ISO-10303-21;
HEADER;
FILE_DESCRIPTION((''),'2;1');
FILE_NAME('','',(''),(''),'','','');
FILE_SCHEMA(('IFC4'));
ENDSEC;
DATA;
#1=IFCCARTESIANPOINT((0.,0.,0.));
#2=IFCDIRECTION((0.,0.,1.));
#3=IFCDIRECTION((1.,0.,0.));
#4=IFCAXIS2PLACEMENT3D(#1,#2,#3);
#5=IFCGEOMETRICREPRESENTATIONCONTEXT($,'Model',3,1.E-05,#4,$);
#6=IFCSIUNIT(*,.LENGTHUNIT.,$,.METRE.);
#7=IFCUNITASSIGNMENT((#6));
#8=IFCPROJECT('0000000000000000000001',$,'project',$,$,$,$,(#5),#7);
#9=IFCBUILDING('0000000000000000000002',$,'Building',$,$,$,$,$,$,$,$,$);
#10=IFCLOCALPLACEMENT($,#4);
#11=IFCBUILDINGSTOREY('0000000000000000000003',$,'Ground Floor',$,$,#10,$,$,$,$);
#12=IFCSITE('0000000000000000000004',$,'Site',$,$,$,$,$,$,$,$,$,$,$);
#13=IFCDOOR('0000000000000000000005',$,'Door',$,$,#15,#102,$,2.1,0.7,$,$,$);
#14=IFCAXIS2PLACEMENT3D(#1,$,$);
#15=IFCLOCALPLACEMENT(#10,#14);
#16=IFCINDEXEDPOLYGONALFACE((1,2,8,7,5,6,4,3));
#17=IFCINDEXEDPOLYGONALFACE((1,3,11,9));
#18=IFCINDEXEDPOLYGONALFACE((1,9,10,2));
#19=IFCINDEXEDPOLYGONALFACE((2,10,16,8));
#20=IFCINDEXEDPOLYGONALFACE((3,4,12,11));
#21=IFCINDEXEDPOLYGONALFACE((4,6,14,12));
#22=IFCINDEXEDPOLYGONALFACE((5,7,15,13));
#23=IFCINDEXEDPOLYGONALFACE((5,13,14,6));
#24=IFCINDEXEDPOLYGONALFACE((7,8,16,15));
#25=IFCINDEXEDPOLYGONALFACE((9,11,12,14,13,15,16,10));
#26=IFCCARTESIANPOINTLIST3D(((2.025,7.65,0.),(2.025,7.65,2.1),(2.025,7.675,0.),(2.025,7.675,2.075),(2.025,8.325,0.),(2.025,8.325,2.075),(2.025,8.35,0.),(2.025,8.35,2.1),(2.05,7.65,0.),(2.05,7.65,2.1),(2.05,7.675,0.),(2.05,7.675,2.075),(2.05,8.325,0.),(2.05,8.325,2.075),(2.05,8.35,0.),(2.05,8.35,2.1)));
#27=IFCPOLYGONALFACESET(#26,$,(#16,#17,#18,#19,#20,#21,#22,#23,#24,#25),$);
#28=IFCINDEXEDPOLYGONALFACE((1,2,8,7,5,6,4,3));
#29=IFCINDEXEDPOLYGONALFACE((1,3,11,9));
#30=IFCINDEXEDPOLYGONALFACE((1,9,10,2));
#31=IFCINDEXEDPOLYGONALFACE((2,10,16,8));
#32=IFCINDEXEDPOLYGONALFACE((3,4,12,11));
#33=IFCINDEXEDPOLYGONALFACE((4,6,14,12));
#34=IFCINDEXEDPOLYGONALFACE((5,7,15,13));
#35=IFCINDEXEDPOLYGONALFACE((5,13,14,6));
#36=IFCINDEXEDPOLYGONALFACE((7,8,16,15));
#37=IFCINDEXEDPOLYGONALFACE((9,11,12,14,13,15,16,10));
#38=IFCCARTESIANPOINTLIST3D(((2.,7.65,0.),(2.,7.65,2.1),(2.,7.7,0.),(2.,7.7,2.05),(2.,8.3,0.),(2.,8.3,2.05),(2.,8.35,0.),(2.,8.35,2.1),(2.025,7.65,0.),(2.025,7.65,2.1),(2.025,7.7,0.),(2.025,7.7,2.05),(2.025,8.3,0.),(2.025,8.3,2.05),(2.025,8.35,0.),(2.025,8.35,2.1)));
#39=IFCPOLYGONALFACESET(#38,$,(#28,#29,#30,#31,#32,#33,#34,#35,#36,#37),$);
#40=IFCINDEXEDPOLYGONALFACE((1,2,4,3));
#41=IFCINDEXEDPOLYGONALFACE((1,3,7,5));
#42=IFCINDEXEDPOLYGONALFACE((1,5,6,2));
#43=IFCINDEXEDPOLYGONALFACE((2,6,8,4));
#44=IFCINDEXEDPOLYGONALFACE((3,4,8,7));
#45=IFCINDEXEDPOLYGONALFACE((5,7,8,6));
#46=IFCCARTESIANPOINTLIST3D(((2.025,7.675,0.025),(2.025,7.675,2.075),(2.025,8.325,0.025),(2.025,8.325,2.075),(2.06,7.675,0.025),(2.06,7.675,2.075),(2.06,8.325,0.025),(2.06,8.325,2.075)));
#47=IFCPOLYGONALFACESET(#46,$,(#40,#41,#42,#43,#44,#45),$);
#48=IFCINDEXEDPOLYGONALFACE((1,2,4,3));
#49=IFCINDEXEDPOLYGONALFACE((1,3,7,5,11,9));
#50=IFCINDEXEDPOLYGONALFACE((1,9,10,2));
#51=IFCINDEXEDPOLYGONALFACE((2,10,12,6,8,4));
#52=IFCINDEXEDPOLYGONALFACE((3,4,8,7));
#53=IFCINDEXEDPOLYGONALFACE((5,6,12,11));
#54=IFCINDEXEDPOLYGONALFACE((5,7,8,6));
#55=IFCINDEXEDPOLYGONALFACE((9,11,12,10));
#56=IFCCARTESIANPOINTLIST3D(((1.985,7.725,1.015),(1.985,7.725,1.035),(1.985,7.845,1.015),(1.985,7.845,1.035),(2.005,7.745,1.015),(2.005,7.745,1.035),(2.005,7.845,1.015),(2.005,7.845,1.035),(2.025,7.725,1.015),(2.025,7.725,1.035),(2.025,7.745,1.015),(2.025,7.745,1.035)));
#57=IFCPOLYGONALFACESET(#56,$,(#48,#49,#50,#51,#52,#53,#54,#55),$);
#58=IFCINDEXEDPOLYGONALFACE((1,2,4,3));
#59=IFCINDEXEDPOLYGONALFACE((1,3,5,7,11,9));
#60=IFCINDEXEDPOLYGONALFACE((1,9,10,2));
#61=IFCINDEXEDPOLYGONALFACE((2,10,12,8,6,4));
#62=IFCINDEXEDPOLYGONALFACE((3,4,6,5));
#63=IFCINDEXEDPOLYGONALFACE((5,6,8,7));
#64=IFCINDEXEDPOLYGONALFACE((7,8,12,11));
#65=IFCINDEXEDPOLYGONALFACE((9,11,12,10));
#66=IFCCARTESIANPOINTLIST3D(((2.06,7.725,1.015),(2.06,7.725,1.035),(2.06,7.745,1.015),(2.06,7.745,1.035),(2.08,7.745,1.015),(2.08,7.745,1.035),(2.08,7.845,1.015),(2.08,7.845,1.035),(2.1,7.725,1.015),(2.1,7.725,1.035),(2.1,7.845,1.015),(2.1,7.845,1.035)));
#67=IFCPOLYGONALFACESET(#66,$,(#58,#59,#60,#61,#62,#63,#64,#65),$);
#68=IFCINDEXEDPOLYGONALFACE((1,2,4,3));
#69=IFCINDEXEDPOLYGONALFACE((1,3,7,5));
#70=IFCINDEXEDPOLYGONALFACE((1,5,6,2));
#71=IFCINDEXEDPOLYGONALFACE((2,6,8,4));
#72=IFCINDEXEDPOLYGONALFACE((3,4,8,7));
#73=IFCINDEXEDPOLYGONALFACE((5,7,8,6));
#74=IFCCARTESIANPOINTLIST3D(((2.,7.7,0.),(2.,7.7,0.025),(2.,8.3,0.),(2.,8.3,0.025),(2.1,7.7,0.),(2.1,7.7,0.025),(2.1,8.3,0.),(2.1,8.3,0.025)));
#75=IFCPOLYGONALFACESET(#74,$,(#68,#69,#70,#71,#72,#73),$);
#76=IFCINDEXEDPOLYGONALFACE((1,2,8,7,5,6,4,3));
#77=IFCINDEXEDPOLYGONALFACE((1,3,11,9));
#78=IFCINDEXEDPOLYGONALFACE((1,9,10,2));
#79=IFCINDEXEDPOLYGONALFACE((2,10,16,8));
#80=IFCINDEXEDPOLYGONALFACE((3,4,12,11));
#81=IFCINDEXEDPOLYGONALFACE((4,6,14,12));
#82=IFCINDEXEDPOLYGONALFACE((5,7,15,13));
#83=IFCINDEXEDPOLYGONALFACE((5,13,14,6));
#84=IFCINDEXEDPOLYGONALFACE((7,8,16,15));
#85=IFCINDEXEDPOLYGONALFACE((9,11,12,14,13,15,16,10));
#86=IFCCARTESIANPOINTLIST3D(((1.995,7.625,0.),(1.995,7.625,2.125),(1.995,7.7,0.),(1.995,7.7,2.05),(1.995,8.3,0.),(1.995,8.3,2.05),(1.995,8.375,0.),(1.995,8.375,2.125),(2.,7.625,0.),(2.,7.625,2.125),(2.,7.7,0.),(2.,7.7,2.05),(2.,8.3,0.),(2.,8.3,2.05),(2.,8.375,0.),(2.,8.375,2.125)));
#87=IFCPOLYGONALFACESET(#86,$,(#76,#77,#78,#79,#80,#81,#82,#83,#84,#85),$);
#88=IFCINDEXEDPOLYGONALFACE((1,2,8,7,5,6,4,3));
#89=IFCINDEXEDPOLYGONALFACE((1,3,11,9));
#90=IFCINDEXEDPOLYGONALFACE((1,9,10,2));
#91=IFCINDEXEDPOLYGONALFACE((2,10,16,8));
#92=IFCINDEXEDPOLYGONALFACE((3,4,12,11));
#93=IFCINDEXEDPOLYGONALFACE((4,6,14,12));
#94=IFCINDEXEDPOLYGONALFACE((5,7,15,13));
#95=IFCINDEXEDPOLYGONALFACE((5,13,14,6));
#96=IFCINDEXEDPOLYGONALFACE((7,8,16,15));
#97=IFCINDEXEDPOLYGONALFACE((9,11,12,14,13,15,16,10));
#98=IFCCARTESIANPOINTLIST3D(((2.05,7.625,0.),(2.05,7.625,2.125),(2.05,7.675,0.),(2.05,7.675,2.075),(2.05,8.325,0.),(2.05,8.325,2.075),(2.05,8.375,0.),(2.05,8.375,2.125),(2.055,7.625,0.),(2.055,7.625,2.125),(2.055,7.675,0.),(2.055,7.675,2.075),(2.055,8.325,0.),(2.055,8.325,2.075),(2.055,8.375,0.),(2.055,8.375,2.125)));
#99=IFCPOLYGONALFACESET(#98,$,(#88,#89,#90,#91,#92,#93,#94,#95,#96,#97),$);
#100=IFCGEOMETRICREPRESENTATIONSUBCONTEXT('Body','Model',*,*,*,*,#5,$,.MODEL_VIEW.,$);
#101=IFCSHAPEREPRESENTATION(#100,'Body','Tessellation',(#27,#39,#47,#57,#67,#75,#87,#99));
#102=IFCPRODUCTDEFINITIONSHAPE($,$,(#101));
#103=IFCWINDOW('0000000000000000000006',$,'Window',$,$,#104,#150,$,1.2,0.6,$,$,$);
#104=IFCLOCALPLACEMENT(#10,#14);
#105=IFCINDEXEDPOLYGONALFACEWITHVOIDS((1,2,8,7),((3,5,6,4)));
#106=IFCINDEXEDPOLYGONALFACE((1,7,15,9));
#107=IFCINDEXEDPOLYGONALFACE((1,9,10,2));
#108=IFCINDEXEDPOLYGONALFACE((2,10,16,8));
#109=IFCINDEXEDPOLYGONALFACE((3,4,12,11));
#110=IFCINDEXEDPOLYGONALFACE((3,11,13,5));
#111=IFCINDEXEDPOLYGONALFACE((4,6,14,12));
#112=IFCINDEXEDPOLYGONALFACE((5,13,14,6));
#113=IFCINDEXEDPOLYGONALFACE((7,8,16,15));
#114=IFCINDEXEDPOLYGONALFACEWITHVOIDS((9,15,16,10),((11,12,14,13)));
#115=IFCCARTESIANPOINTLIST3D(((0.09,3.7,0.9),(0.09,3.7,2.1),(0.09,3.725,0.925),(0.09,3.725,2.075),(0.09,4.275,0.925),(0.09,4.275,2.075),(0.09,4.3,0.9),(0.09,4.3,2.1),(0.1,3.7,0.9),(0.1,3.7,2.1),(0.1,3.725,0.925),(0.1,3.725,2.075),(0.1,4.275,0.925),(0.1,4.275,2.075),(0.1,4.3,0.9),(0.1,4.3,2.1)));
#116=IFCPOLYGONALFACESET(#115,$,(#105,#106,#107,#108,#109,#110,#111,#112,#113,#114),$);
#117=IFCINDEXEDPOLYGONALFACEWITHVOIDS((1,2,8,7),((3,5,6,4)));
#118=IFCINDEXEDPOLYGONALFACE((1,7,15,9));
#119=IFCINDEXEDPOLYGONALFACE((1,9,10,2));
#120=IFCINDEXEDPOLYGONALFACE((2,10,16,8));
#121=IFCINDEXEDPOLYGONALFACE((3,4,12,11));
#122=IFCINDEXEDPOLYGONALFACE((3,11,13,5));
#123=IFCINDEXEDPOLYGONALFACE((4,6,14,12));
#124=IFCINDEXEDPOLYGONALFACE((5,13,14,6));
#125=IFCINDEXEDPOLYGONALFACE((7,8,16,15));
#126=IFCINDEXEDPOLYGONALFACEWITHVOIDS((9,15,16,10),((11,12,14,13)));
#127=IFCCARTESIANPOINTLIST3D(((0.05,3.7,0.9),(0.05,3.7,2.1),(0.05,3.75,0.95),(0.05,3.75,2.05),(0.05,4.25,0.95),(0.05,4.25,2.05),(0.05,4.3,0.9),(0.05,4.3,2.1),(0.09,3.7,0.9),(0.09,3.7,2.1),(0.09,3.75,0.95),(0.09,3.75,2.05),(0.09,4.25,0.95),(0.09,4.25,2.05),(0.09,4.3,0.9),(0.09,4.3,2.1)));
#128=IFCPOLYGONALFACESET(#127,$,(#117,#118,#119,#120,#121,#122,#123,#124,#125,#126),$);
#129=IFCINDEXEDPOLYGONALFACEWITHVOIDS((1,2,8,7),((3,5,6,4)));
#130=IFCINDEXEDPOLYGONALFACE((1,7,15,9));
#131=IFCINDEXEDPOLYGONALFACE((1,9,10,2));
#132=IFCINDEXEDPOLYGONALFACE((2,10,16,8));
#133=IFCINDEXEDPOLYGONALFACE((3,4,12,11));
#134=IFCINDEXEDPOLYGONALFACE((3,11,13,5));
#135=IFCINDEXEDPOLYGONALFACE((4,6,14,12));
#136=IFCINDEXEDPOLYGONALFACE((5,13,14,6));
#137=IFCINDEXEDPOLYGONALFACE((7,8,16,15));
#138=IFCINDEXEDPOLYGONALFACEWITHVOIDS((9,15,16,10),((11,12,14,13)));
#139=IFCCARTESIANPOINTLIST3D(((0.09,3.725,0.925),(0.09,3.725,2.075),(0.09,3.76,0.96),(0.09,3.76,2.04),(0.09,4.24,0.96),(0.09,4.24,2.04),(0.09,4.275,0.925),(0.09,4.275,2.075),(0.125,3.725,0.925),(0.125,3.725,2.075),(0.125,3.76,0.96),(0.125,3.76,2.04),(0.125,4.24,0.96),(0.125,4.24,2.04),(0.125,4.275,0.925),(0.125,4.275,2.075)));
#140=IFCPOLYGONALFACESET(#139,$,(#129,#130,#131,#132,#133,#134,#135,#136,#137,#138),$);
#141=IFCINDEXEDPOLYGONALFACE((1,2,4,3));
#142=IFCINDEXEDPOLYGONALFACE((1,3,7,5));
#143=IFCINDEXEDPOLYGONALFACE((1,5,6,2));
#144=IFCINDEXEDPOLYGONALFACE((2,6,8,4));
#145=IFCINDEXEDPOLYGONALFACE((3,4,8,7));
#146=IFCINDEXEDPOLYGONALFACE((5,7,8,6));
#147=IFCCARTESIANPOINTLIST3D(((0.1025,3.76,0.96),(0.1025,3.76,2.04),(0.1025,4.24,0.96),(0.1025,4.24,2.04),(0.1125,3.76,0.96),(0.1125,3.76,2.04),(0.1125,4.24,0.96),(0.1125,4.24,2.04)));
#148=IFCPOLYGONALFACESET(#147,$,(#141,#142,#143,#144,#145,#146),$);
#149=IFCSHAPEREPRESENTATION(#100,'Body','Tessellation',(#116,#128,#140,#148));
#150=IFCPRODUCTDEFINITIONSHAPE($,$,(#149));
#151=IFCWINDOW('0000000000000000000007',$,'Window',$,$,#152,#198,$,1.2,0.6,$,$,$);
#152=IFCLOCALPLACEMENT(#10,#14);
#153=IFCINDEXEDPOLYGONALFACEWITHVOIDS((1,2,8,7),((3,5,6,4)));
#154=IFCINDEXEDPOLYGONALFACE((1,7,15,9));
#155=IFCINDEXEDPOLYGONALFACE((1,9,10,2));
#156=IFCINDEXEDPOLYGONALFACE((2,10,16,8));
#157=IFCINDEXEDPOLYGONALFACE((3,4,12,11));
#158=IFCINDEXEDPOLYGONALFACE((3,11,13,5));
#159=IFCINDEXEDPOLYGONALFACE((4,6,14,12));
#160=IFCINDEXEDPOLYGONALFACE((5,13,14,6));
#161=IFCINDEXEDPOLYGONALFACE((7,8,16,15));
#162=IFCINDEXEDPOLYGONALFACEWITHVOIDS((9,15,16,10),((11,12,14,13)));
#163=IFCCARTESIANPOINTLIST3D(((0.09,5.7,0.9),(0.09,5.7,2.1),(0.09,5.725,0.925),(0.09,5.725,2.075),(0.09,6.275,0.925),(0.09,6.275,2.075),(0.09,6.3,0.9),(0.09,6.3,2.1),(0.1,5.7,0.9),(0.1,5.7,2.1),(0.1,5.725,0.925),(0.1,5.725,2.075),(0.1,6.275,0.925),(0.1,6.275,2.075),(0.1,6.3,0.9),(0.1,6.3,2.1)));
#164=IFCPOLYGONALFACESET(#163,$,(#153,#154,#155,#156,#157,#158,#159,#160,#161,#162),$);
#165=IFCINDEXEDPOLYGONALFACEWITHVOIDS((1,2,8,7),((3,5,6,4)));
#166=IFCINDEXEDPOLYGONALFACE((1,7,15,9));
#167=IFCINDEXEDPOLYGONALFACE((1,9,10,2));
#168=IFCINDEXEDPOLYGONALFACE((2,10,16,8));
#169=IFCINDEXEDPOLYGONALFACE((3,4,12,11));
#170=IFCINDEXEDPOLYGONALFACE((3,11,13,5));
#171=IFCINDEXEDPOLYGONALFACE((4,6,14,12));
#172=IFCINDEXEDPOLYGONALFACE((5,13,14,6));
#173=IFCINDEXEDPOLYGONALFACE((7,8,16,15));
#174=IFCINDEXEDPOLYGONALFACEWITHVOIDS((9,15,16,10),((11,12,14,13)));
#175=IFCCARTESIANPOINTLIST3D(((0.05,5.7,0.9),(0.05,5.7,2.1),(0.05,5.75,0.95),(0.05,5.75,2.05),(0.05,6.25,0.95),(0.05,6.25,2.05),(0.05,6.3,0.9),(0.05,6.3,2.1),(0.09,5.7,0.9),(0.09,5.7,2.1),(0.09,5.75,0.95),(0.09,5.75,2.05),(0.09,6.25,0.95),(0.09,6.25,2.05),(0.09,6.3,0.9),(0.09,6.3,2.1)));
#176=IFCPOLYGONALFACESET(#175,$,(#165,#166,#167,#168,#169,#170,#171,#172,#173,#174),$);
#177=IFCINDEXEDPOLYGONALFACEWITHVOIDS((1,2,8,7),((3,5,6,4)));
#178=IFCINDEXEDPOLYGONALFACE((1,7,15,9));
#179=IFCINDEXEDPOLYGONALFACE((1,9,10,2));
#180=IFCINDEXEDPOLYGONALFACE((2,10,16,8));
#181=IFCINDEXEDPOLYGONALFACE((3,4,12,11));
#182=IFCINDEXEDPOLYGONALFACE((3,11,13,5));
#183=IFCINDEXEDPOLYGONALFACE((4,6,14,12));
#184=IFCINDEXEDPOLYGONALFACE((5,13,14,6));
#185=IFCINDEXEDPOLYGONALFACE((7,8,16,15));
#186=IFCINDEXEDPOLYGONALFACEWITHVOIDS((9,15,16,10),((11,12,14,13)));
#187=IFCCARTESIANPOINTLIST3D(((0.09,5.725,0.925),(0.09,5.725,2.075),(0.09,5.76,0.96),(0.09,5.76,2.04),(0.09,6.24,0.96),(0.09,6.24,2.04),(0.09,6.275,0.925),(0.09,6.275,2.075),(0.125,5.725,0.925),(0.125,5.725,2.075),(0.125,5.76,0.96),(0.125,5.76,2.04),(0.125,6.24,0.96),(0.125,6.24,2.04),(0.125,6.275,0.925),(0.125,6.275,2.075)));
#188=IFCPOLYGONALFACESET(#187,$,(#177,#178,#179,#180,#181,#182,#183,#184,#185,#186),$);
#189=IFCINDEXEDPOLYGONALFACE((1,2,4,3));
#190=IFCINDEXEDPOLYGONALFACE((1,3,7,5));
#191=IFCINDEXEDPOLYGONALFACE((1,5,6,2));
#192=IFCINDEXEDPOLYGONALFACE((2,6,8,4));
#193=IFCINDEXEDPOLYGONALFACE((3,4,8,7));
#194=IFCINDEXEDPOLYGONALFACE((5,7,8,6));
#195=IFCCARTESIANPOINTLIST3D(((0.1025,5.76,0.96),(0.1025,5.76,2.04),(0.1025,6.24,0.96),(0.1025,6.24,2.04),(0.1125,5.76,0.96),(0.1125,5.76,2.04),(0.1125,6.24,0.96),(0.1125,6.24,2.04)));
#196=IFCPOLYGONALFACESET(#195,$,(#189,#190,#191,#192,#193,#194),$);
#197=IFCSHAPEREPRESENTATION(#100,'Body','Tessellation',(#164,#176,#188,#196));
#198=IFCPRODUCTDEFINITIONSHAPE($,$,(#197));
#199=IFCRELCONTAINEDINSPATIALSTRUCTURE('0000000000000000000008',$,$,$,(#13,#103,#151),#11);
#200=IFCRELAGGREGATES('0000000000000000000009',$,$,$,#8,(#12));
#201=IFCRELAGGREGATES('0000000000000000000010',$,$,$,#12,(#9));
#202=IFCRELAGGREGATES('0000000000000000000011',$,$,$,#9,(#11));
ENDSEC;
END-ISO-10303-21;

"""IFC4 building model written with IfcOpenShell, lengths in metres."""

from ifc_helpers import new_model, si_unit, frame, origin_with_axes, place, context, subcontext, project, spatial, line, indexed_curve, outline, extrude, element, save


model = new_model("IFC4")

# Units and contexts
model_context = context("Model", 3, precision=1e-05, world=origin_with_axes())
body_context = subcontext(model_context, "Body", "Model", "MODEL_VIEW")
ifc_project = project(units=[si_unit("LENGTHUNIT", "METRE")], contexts=[model_context])

# Site, building, storey
site = spatial("IfcSite", under=ifc_project, Name="Site")
building = spatial("IfcBuilding", under=site, Name="Building")
storey_placement = place(None, origin_with_axes())
storey = spatial("IfcBuildingStorey", under=building, at=storey_placement, Name="Ground Floor")

# Door
door_1_placement = place(storey_placement, frame((2.0, 8.35, 0.0), z_axis=(0.0, 0.0, 1.0), x_axis=(0.0, -1.0, 0.0)))
element("IfcDoor", 1, at=door_1_placement, inside=storey, Name="Door", OverallHeight=2.1, OverallWidth=0.7, context=body_context, shape_type="SweptSolid", body=[
    extrude(outline(indexed_curve([(0.0, 0.0), (0.0, 2.1), (0.7, 2.1), (0.7, 0.0), (0.675, 0.0), (0.675, 2.075), (0.025, 2.075), (0.025, 0.0)], segments=[line(1, 2, 3, 4, 5, 6, 7, 8, 1)])), frame((0.0, 0.025, 0.0), z_axis=(0.0, -1.0, 0.0), x_axis=(1.0, 0.0, 0.0)), (0.0, 0.0, -1.0), 0.025),
    extrude(outline(indexed_curve([(0.0, 0.0), (0.0, 2.1), (0.7, 2.1), (0.7, 0.0), (0.65, 0.0), (0.65, 2.05), (0.05, 2.05), (0.05, 0.0)], segments=[line(1, 2, 3, 4, 5, 6, 7, 8, 1)])), frame((0.0, 0.0, 0.0), z_axis=(0.0, -1.0, 0.0), x_axis=(1.0, 0.0, 0.0)), (0.0, 0.0, -1.0), 0.025),
    extrude(outline(indexed_curve([(0.0, 0.0), (0.65, 0.0), (0.65, 0.035), (0.0, 0.035)], segments=[line(1, 2, 3, 4, 1)])), frame((0.025, 0.025, 0.025), z_axis=(0.0, 0.0, 1.0), x_axis=(1.0, 0.0, 0.0)), (0.0, 0.0, 1.0), 2.05),
    extrude(outline(indexed_curve([(0.0, 0.0), (0.0, -0.04), (-0.12, -0.04), (-0.12, -0.02), (-0.02, -0.02), (-0.02, 0.0)], segments=[line(1, 2, 3, 4, 5, 6, 1)])), frame((0.625, 0.025, 1.015), z_axis=(0.0, 0.0, 1.0), x_axis=(1.0, 0.0, 0.0)), (0.0, 0.0, 1.0), 0.02),
    extrude(outline(indexed_curve([(0.0, 0.0), (0.0, 0.04), (-0.12, 0.04), (-0.12, 0.02), (-0.02, 0.02), (-0.02, 0.0)], segments=[line(1, 2, 3, 4, 5, 6, 1)])), frame((0.625, 0.06, 1.015), z_axis=(0.0, 0.0, 1.0), x_axis=(1.0, 0.0, 0.0)), (0.0, 0.0, 1.0), 0.02),
    extrude(outline(indexed_curve([(0.0, 0.0), (0.6, 0.0), (0.6, 0.1), (0.0, 0.1)], segments=[line(1, 2, 3, 4, 1)])), frame((0.05, 0.0, 0.0), z_axis=(0.0, 0.0, 1.0), x_axis=(1.0, 0.0, 0.0)), (0.0, 0.0, 1.0), 0.025),
    extrude(outline(indexed_curve([(0.0, 0.0), (0.0, 2.125), (0.75, 2.125), (0.75, 0.0), (0.675, 0.0), (0.675, 2.05), (0.075, 2.05), (0.075, 0.0)], segments=[line(1, 2, 3, 4, 5, 6, 7, 8, 1)])), frame((-0.025, -0.005, 0.0), z_axis=(0.0, -1.0, 0.0), x_axis=(1.0, 0.0, 0.0)), (0.0, 0.0, -1.0), 0.005),
    extrude(outline(indexed_curve([(0.0, 0.0), (0.0, 2.125), (0.75, 2.125), (0.75, 0.0), (0.7, 0.0), (0.7, 2.075), (0.05, 2.075), (0.05, 0.0)], segments=[line(1, 2, 3, 4, 5, 6, 7, 8, 1)])), frame((-0.025, 0.05, 0.0), z_axis=(0.0, -1.0, 0.0), x_axis=(1.0, 0.0, 0.0)), (0.0, 0.0, -1.0), 0.005),
])

# Windows
for number, where, z_axis, x_axis, name in (
    (2, (0.0, 4.3, 0.9), (0.0, 0.0, 1.0), (0.0, -1.0, 0.0), "Window"),
    (3, (0.0, 6.3, 0.9), (0.0, 0.0, 1.0), (0.0, -1.0, 0.0), "Window"),
):
    element("IfcWindow", number, at=place(storey_placement, frame(where, z_axis=z_axis, x_axis=x_axis)), inside=storey, Name=name, OverallHeight=1.2, OverallWidth=0.6, context=body_context, shape_type="SweptSolid", body=[
        extrude(outline(indexed_curve([(0.0, 0.0), (0.6, 0.0), (0.6, 1.2), (0.0, 1.2)], segments=[line(1, 2, 3, 4, 1)]), holes=[indexed_curve([(0.025, 0.025), (0.575, 0.025), (0.575, 1.175), (0.025, 1.175)], segments=[line(1, 2, 3, 4, 1)])]), frame((0.0, 0.09, 0.0), z_axis=(0.0, -1.0, 0.0), x_axis=(1.0, 0.0, 0.0)), (0.0, 0.0, -1.0), 0.01),
        extrude(outline(indexed_curve([(0.0, 0.0), (0.6, 0.0), (0.6, 1.2), (0.0, 1.2)], segments=[line(1, 2, 3, 4, 1)]), holes=[indexed_curve([(0.05, 0.05), (0.55, 0.05), (0.55, 1.15), (0.05, 1.15)], segments=[line(1, 2, 3, 4, 1)])]), frame((0.0, 0.05, 0.0), z_axis=(0.0, -1.0, 0.0), x_axis=(1.0, 0.0, 0.0)), (0.0, 0.0, -1.0), 0.04),
        extrude(outline(indexed_curve([(0.0, 0.0), (0.55, 0.0), (0.55, 1.15), (0.0, 1.15)], segments=[line(1, 2, 3, 4, 1)]), holes=[indexed_curve([(0.035, 0.035), (0.515, 0.035), (0.515, 1.115), (0.035, 1.115)], segments=[line(1, 2, 3, 4, 1)])]), frame((0.025, 0.09, 0.025), z_axis=(0.0, -1.0, 0.0), x_axis=(1.0, 0.0, 0.0)), (0.0, 0.0, -1.0), 0.035),
        extrude(outline(indexed_curve([(0.035, 0.035), (0.515, 0.035), (0.515, 1.115), (0.035, 1.115)], segments=[line(1, 2, 3, 4, 1)])), frame((0.025, 0.1025, 0.025), z_axis=(0.0, -1.0, 0.0), x_axis=(1.0, 0.0, 0.0)), (0.0, 0.0, -1.0), 0.01),
    ])

save(model, "model.ifc")
